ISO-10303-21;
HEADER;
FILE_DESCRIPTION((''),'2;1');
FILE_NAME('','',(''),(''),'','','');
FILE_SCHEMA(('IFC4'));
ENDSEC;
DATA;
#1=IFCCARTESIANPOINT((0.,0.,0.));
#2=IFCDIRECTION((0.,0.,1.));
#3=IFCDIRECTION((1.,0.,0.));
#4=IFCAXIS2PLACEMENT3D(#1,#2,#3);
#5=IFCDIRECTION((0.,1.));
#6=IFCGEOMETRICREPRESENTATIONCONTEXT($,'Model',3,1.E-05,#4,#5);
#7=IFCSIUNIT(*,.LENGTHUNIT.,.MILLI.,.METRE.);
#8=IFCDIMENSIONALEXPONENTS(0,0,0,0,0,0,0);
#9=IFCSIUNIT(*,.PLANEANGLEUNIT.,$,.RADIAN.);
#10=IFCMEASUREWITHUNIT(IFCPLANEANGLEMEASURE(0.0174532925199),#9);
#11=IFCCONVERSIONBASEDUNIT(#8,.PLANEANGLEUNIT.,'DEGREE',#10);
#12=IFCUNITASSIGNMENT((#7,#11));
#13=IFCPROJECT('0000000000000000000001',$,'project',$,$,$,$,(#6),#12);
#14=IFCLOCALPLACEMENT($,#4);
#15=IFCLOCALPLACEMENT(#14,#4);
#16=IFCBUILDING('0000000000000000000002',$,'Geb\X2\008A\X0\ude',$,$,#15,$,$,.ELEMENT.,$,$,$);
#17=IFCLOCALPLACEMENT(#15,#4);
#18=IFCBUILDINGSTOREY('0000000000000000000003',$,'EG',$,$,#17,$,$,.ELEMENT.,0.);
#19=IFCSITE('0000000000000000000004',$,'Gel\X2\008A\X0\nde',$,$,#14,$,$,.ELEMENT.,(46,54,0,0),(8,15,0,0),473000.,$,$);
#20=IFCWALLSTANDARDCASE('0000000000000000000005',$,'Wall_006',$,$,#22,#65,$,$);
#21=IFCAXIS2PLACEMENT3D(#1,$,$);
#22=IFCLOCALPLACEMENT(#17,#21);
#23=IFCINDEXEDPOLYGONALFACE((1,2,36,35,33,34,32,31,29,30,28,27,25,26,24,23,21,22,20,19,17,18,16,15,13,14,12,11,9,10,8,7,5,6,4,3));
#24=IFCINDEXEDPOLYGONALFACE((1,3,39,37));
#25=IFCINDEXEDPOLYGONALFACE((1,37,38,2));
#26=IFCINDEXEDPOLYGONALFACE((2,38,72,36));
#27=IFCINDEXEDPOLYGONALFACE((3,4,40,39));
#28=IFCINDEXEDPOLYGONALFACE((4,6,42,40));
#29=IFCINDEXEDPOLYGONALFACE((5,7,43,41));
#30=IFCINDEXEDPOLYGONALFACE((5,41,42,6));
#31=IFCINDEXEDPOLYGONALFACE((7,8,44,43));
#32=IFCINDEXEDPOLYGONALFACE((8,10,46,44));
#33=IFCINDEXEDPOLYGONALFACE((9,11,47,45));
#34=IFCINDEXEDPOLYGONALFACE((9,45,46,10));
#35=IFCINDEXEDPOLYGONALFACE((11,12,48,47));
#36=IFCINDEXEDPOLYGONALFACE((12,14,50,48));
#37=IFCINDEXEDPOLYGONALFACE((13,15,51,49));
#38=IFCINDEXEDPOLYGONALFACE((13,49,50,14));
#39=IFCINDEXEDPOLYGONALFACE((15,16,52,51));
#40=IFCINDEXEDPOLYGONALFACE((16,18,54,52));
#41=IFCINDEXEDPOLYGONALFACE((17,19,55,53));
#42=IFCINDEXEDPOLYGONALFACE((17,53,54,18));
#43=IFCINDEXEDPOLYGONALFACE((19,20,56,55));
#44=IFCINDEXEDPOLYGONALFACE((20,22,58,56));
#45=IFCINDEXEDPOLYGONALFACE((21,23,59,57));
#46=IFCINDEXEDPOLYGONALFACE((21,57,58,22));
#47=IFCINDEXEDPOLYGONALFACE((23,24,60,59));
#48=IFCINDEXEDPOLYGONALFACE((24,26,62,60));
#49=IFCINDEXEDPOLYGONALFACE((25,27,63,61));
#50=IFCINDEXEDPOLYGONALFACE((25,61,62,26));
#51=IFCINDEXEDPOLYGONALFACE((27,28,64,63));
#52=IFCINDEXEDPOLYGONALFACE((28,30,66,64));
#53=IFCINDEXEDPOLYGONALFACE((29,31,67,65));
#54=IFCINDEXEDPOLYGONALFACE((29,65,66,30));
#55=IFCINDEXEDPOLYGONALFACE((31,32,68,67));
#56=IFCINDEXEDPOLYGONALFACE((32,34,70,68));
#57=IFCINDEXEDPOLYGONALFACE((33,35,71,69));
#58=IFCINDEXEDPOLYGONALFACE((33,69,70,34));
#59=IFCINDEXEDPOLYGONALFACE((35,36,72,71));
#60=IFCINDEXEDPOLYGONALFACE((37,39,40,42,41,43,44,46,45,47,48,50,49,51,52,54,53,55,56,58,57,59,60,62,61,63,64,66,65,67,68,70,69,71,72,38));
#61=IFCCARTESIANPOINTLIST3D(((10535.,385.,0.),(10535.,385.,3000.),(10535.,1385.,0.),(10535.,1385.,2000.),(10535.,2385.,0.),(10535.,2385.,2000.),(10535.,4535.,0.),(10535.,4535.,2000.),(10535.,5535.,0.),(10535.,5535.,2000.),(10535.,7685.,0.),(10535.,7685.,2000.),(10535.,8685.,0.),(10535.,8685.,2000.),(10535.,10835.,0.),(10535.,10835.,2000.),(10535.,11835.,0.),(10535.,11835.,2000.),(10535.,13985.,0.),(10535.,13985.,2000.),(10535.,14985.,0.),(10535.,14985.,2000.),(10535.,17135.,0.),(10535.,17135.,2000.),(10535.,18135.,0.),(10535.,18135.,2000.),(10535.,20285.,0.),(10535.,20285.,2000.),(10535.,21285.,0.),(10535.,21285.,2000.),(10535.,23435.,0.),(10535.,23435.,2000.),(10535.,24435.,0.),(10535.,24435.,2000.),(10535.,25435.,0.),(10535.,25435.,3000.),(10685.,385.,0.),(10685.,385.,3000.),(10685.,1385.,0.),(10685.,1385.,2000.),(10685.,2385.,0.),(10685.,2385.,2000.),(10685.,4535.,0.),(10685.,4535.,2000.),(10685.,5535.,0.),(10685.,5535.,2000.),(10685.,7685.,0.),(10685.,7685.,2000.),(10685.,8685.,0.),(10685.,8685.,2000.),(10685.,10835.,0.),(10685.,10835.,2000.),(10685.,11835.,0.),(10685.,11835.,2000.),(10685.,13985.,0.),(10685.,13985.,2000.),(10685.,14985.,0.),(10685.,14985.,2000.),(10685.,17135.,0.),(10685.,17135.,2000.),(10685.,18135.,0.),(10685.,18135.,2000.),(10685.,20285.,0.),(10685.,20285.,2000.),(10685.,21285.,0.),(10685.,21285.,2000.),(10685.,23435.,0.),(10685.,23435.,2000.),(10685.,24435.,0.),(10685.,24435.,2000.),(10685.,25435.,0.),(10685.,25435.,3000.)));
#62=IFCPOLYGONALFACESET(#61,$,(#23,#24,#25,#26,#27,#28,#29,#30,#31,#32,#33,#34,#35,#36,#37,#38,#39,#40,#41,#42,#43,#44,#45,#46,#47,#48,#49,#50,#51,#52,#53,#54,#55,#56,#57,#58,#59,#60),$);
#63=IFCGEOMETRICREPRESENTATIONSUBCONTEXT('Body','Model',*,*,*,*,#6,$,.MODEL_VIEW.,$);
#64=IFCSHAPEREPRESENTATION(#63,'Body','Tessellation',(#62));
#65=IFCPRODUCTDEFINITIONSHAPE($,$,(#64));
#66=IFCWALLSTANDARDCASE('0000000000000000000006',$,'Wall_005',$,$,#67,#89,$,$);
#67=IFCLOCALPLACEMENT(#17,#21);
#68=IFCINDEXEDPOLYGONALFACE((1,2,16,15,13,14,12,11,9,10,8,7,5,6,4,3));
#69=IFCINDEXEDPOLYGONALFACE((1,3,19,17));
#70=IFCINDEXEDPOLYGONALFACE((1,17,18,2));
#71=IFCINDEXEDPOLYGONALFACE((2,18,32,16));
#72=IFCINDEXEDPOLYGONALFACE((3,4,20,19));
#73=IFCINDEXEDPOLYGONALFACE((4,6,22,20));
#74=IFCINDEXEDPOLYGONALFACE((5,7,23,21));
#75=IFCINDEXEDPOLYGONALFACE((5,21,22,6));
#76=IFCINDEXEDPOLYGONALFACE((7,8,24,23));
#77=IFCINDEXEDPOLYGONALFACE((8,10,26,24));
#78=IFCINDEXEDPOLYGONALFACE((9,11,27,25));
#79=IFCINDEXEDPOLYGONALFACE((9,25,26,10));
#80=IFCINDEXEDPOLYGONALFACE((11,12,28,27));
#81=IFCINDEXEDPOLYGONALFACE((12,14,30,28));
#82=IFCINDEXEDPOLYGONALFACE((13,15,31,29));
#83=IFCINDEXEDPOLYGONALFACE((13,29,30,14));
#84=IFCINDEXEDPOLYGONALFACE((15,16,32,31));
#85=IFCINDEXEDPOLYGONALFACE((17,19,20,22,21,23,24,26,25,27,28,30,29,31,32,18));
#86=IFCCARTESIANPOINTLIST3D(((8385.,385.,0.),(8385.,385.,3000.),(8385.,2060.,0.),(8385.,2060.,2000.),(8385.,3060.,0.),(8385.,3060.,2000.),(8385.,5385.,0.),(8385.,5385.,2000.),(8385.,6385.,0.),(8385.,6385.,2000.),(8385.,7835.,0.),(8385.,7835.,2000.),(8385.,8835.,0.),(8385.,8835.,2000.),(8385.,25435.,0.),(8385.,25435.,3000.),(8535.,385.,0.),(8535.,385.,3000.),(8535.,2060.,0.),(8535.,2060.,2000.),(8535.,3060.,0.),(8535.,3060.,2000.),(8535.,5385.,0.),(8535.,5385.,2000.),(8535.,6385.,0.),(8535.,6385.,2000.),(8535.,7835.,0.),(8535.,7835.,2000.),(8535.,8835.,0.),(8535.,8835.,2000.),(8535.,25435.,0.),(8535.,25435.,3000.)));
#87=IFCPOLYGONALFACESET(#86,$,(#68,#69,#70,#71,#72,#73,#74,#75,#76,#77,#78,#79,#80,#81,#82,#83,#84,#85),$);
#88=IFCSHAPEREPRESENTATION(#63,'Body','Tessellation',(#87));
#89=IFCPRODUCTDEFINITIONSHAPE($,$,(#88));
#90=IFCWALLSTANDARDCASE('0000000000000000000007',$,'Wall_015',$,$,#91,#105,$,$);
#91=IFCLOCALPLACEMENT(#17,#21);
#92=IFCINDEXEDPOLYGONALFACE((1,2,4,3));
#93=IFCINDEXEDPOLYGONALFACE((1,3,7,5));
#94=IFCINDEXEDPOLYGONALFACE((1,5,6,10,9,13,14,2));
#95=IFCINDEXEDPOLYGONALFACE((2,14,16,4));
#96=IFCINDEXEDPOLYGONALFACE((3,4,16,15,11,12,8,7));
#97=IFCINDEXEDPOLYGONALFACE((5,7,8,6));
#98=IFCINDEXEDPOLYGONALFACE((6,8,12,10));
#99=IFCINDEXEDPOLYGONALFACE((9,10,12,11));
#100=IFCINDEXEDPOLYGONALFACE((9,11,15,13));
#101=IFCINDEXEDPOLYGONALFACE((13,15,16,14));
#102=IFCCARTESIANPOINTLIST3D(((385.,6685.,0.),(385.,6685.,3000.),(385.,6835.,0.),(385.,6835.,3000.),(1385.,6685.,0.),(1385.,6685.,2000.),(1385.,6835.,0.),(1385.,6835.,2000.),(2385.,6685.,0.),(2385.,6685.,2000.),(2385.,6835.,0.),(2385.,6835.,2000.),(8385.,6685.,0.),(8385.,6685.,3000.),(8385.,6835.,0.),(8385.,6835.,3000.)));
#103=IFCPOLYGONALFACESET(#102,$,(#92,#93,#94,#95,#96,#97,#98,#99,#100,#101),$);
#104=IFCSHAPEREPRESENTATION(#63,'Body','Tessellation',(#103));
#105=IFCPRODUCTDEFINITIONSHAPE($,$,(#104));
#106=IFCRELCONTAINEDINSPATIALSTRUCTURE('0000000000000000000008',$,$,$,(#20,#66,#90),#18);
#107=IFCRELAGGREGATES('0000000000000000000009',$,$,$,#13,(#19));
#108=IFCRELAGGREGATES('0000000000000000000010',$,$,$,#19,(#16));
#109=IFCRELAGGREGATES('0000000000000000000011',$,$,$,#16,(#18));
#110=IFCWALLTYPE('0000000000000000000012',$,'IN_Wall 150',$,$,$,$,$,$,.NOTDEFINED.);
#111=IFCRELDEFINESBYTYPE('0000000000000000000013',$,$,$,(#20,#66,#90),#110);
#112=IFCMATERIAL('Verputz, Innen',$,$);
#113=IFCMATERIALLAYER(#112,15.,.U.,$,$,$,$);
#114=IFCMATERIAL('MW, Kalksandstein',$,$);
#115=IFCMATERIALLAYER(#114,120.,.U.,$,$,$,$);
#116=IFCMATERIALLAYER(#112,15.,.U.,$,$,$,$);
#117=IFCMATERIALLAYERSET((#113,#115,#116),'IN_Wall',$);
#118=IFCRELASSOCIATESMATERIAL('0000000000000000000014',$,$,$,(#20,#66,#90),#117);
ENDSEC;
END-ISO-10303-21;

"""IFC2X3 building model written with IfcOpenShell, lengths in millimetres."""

from ifc_helpers import new_model, entity, si_unit, converted_unit, direction, frame, origin_with_axes, origin_2d_with_axis, place, context, subcontext, project, spatial, polyline, rectangle, outline, extrude, material, layer, layer_set, layer_usage, type_object, element, save


model = new_model("IFC2X3")

# Units and contexts
model_context = context("Model", 3, precision=1e-05, world=origin_with_axes(), true_north=direction((0.0, 1.0)))
body_context = subcontext(model_context, "Body", "Model", "MODEL_VIEW")
ifc_project = project(units=[si_unit("LENGTHUNIT", "METRE", prefix="MILLI"), converted_unit("PLANEANGLEUNIT", "DEGREE", entity("IfcPlaneAngleMeasure", 0.0174532925199), si_unit("PLANEANGLEUNIT", "RADIAN"), dimensions=[0, 0, 0, 0, 0, 0, 0])], contexts=[model_context])

# Site, building, storey
site_placement = place(None, origin_with_axes())
site = spatial("IfcSite", under=ifc_project, at=site_placement, Name="Gel\u008ande", CompositionType="ELEMENT", RefLatitude=(46, 54, 0, 0), RefLongitude=(8, 15, 0, 0), RefElevation=473000.0)
building_placement = place(site_placement, origin_with_axes())
building = spatial("IfcBuilding", under=site, at=building_placement, Name="Geb\u008aude", CompositionType="ELEMENT")
storey_placement = place(building_placement, origin_with_axes())
storey = spatial("IfcBuildingStorey", under=building, at=storey_placement, Name="EG", CompositionType="ELEMENT", Elevation=0.0)

# Wall, openings
ifc_material_1 = material(Name="Verputz, Innen")
ifc_layer_1 = layer(ifc_material_1, 15.0, ventilated="UNKNOWN")
ifc_material_2 = material(Name="MW, Kalksandstein")
ifc_layer_2 = layer(ifc_material_2, 120.0, ventilated="UNKNOWN")
ifc_layer_3 = layer(ifc_material_1, 15.0, ventilated="UNKNOWN")
ifc_layer_set_1 = layer_set([ifc_layer_1, ifc_layer_2, ifc_layer_3], Name="IN_Wall")
ifc_layer_usage_1 = layer_usage(ifc_layer_set_1, "AXIS2", "POSITIVE", 0.0)
wall_type_1 = type_object("IfcWallType", Name="IN_Wall 150", PredefinedType="NOTDEFINED")
wall_1_placement = place(storey_placement, frame((10535.0, 25820.0, 0.0), z_axis=(0.0, 0.0, 1.0), x_axis=(0.0, -1.0, 0.0)))
wall_1 = element("IfcWallStandardCase", 1, at=wall_1_placement, inside=storey, type_object=wall_type_1, material=ifc_layer_usage_1, Name="Wall_006", context=body_context, shape_type="SweptSolid", body=[
    extrude(outline(polyline([(385.0, 0.0), (25435.0, 0.0), (25435.0, 150.0), (385.0, 150.0), (385.0, 0.0)])), origin_with_axes(), (0.0, 0.0, 1.0), 3000.0),
])
opening_1_placement = place(wall_1_placement, frame((1885.0, 0.0, 0.0), z_axis=(0.0, 0.0, 1.0), x_axis=(1.0, 0.0, 0.0)))
element("IfcOpeningElement", 2, at=opening_1_placement, cuts=wall_1, context=body_context, shape_type="SweptSolid", body=[
    extrude(rectangle(XDim=1000.0, YDim=2000.0, at=origin_2d_with_axis()), frame((0.0, -150.0, 1000.0), z_axis=(0.0, -1.0, 0.0), x_axis=(-1.0, 0.0, 0.0)), (0.0, 0.0, -1.0), 450.0),
])
opening_2_placement = place(wall_1_placement, frame((5035.0, 0.0, 0.0), z_axis=(0.0, 0.0, 1.0), x_axis=(1.0, 0.0, 0.0)))
element("IfcOpeningElement", 3, at=opening_2_placement, cuts=wall_1, context=body_context, shape_type="SweptSolid", body=[
    extrude(rectangle(XDim=1000.0, YDim=2000.0, at=origin_2d_with_axis()), frame((0.0, -150.0, 1000.0), z_axis=(0.0, -1.0, 0.0), x_axis=(-1.0, 0.0, 0.0)), (0.0, 0.0, -1.0), 450.0),
])
opening_3_placement = place(wall_1_placement, frame((8185.0, 0.0, 0.0), z_axis=(0.0, 0.0, 1.0), x_axis=(1.0, 0.0, 0.0)))
element("IfcOpeningElement", 4, at=opening_3_placement, cuts=wall_1, context=body_context, shape_type="SweptSolid", body=[
    extrude(rectangle(XDim=1000.0, YDim=2000.0, at=origin_2d_with_axis()), frame((0.0, -150.0, 1000.0), z_axis=(0.0, -1.0, 0.0), x_axis=(-1.0, 0.0, 0.0)), (0.0, 0.0, -1.0), 450.0),
])
opening_4_placement = place(wall_1_placement, frame((11335.0, 0.0, 0.0), z_axis=(0.0, 0.0, 1.0), x_axis=(1.0, 0.0, 0.0)))
element("IfcOpeningElement", 5, at=opening_4_placement, cuts=wall_1, context=body_context, shape_type="SweptSolid", body=[
    extrude(rectangle(XDim=1000.0, YDim=2000.0, at=origin_2d_with_axis()), frame((0.0, -150.0, 1000.0), z_axis=(0.0, -1.0, 0.0), x_axis=(-1.0, 0.0, 0.0)), (0.0, 0.0, -1.0), 450.0),
])
opening_5_placement = place(wall_1_placement, frame((14485.0, 0.0, 0.0), z_axis=(0.0, 0.0, 1.0), x_axis=(1.0, 0.0, 0.0)))
element("IfcOpeningElement", 6, at=opening_5_placement, cuts=wall_1, context=body_context, shape_type="SweptSolid", body=[
    extrude(rectangle(XDim=1000.0, YDim=2000.0, at=origin_2d_with_axis()), frame((0.0, -150.0, 1000.0), z_axis=(0.0, -1.0, 0.0), x_axis=(-1.0, 0.0, 0.0)), (0.0, 0.0, -1.0), 450.0),
])
opening_6_placement = place(wall_1_placement, frame((17635.0, 0.0, 0.0), z_axis=(0.0, 0.0, 1.0), x_axis=(1.0, 0.0, 0.0)))
element("IfcOpeningElement", 7, at=opening_6_placement, cuts=wall_1, context=body_context, shape_type="SweptSolid", body=[
    extrude(rectangle(XDim=1000.0, YDim=2000.0, at=origin_2d_with_axis()), frame((0.0, -150.0, 1000.0), z_axis=(0.0, -1.0, 0.0), x_axis=(-1.0, 0.0, 0.0)), (0.0, 0.0, -1.0), 450.0),
])
opening_7_placement = place(wall_1_placement, frame((20785.0, 0.0, 0.0), z_axis=(0.0, 0.0, 1.0), x_axis=(1.0, 0.0, 0.0)))
element("IfcOpeningElement", 8, at=opening_7_placement, cuts=wall_1, context=body_context, shape_type="SweptSolid", body=[
    extrude(rectangle(XDim=1000.0, YDim=2000.0, at=origin_2d_with_axis()), frame((0.0, -150.0, 1000.0), z_axis=(0.0, -1.0, 0.0), x_axis=(-1.0, 0.0, 0.0)), (0.0, 0.0, -1.0), 450.0),
])
opening_8_placement = place(wall_1_placement, frame((23935.0, 0.0, 0.0), z_axis=(0.0, 0.0, 1.0), x_axis=(1.0, 0.0, 0.0)))
element("IfcOpeningElement", 9, at=opening_8_placement, cuts=wall_1, context=body_context, shape_type="SweptSolid", body=[
    extrude(rectangle(XDim=1000.0, YDim=2000.0, at=origin_2d_with_axis()), frame((0.0, -150.0, 1000.0), z_axis=(0.0, -1.0, 0.0), x_axis=(-1.0, 0.0, 0.0)), (0.0, 0.0, -1.0), 450.0),
])

# Wall, openings
ifc_layer_usage_2 = layer_usage(ifc_layer_set_1, "AXIS2", "POSITIVE", 0.0)
wall_2_placement = place(storey_placement, frame((8385.0, 25820.0, 0.0), z_axis=(0.0, 0.0, 1.0), x_axis=(0.0, -1.0, 0.0)))
wall_2 = element("IfcWallStandardCase", 10, at=wall_2_placement, inside=storey, type_object=wall_type_1, material=ifc_layer_usage_2, Name="Wall_005", context=body_context, shape_type="SweptSolid", body=[
    extrude(outline(polyline([(385.0, 0.0), (25435.0, 0.0), (25435.0, 150.0), (385.0, 150.0), (385.0, 0.0)])), origin_with_axes(), (0.0, 0.0, 1.0), 3000.0),
])
opening_9_placement = place(wall_2_placement, frame((17485.0, 0.0, 0.0), z_axis=(0.0, 0.0, 1.0), x_axis=(1.0, 0.0, 0.0)))
element("IfcOpeningElement", 11, at=opening_9_placement, cuts=wall_2, context=body_context, shape_type="SweptSolid", body=[
    extrude(rectangle(XDim=1000.0, YDim=2000.0, at=origin_2d_with_axis()), frame((0.0, -150.0, 1000.0), z_axis=(0.0, -1.0, 0.0), x_axis=(1.0, 0.0, 0.0)), (0.0, 0.0, -1.0), 450.0),
])
opening_10_placement = place(wall_2_placement, frame((23260.0, 0.0, 0.0), z_axis=(0.0, 0.0, 1.0), x_axis=(1.0, 0.0, 0.0)))
element("IfcOpeningElement", 12, at=opening_10_placement, cuts=wall_2, context=body_context, shape_type="SweptSolid", body=[
    extrude(rectangle(XDim=1000.0, YDim=2000.0, at=origin_2d_with_axis()), frame((0.0, 150.0, 1000.0), z_axis=(0.0, -1.0, 0.0), x_axis=(-1.0, 0.0, 0.0)), (0.0, 0.0, 1.0), 450.0),
])
opening_11_placement = place(wall_2_placement, frame((19935.0, 0.0, 0.0), z_axis=(0.0, 0.0, 1.0), x_axis=(1.0, 0.0, 0.0)))
element("IfcOpeningElement", 13, at=opening_11_placement, cuts=wall_2, context=body_context, shape_type="SweptSolid", body=[
    extrude(rectangle(XDim=1000.0, YDim=2000.0, at=origin_2d_with_axis()), frame((0.0, 150.0, 1000.0), z_axis=(0.0, -1.0, 0.0), x_axis=(-1.0, 0.0, 0.0)), (0.0, 0.0, 1.0), 450.0),
])

# Wall, opening
ifc_layer_usage_3 = layer_usage(ifc_layer_set_1, "AXIS2", "POSITIVE", 0.0)
wall_3_placement = place(storey_placement, frame((8385.0, 6835.0, 0.0), z_axis=(0.0, 0.0, 1.0), x_axis=(-1.0, 0.0, 0.0)))
wall_3 = element("IfcWallStandardCase", 14, at=wall_3_placement, inside=storey, type_object=wall_type_1, material=ifc_layer_usage_3, Name="Wall_015", context=body_context, shape_type="SweptSolid", body=[
    extrude(outline(polyline([(0.0, 0.0), (8000.0, 0.0), (8000.0, 150.0), (0.0, 150.0), (0.0, 0.0)])), origin_with_axes(), (0.0, 0.0, 1.0), 3000.0),
])
opening_12_placement = place(wall_3_placement, frame((6500.0, 0.0, 0.0), z_axis=(0.0, 0.0, 1.0), x_axis=(1.0, 0.0, 0.0)))
element("IfcOpeningElement", 15, at=opening_12_placement, cuts=wall_3, context=body_context, shape_type="SweptSolid", body=[
    extrude(rectangle(XDim=1000.0, YDim=2000.0, at=origin_2d_with_axis()), frame((0.0, -150.0, 1000.0), z_axis=(0.0, -1.0, 0.0), x_axis=(-1.0, 0.0, 0.0)), (0.0, 0.0, -1.0), 450.0),
])

save(model, "model.ifc")
